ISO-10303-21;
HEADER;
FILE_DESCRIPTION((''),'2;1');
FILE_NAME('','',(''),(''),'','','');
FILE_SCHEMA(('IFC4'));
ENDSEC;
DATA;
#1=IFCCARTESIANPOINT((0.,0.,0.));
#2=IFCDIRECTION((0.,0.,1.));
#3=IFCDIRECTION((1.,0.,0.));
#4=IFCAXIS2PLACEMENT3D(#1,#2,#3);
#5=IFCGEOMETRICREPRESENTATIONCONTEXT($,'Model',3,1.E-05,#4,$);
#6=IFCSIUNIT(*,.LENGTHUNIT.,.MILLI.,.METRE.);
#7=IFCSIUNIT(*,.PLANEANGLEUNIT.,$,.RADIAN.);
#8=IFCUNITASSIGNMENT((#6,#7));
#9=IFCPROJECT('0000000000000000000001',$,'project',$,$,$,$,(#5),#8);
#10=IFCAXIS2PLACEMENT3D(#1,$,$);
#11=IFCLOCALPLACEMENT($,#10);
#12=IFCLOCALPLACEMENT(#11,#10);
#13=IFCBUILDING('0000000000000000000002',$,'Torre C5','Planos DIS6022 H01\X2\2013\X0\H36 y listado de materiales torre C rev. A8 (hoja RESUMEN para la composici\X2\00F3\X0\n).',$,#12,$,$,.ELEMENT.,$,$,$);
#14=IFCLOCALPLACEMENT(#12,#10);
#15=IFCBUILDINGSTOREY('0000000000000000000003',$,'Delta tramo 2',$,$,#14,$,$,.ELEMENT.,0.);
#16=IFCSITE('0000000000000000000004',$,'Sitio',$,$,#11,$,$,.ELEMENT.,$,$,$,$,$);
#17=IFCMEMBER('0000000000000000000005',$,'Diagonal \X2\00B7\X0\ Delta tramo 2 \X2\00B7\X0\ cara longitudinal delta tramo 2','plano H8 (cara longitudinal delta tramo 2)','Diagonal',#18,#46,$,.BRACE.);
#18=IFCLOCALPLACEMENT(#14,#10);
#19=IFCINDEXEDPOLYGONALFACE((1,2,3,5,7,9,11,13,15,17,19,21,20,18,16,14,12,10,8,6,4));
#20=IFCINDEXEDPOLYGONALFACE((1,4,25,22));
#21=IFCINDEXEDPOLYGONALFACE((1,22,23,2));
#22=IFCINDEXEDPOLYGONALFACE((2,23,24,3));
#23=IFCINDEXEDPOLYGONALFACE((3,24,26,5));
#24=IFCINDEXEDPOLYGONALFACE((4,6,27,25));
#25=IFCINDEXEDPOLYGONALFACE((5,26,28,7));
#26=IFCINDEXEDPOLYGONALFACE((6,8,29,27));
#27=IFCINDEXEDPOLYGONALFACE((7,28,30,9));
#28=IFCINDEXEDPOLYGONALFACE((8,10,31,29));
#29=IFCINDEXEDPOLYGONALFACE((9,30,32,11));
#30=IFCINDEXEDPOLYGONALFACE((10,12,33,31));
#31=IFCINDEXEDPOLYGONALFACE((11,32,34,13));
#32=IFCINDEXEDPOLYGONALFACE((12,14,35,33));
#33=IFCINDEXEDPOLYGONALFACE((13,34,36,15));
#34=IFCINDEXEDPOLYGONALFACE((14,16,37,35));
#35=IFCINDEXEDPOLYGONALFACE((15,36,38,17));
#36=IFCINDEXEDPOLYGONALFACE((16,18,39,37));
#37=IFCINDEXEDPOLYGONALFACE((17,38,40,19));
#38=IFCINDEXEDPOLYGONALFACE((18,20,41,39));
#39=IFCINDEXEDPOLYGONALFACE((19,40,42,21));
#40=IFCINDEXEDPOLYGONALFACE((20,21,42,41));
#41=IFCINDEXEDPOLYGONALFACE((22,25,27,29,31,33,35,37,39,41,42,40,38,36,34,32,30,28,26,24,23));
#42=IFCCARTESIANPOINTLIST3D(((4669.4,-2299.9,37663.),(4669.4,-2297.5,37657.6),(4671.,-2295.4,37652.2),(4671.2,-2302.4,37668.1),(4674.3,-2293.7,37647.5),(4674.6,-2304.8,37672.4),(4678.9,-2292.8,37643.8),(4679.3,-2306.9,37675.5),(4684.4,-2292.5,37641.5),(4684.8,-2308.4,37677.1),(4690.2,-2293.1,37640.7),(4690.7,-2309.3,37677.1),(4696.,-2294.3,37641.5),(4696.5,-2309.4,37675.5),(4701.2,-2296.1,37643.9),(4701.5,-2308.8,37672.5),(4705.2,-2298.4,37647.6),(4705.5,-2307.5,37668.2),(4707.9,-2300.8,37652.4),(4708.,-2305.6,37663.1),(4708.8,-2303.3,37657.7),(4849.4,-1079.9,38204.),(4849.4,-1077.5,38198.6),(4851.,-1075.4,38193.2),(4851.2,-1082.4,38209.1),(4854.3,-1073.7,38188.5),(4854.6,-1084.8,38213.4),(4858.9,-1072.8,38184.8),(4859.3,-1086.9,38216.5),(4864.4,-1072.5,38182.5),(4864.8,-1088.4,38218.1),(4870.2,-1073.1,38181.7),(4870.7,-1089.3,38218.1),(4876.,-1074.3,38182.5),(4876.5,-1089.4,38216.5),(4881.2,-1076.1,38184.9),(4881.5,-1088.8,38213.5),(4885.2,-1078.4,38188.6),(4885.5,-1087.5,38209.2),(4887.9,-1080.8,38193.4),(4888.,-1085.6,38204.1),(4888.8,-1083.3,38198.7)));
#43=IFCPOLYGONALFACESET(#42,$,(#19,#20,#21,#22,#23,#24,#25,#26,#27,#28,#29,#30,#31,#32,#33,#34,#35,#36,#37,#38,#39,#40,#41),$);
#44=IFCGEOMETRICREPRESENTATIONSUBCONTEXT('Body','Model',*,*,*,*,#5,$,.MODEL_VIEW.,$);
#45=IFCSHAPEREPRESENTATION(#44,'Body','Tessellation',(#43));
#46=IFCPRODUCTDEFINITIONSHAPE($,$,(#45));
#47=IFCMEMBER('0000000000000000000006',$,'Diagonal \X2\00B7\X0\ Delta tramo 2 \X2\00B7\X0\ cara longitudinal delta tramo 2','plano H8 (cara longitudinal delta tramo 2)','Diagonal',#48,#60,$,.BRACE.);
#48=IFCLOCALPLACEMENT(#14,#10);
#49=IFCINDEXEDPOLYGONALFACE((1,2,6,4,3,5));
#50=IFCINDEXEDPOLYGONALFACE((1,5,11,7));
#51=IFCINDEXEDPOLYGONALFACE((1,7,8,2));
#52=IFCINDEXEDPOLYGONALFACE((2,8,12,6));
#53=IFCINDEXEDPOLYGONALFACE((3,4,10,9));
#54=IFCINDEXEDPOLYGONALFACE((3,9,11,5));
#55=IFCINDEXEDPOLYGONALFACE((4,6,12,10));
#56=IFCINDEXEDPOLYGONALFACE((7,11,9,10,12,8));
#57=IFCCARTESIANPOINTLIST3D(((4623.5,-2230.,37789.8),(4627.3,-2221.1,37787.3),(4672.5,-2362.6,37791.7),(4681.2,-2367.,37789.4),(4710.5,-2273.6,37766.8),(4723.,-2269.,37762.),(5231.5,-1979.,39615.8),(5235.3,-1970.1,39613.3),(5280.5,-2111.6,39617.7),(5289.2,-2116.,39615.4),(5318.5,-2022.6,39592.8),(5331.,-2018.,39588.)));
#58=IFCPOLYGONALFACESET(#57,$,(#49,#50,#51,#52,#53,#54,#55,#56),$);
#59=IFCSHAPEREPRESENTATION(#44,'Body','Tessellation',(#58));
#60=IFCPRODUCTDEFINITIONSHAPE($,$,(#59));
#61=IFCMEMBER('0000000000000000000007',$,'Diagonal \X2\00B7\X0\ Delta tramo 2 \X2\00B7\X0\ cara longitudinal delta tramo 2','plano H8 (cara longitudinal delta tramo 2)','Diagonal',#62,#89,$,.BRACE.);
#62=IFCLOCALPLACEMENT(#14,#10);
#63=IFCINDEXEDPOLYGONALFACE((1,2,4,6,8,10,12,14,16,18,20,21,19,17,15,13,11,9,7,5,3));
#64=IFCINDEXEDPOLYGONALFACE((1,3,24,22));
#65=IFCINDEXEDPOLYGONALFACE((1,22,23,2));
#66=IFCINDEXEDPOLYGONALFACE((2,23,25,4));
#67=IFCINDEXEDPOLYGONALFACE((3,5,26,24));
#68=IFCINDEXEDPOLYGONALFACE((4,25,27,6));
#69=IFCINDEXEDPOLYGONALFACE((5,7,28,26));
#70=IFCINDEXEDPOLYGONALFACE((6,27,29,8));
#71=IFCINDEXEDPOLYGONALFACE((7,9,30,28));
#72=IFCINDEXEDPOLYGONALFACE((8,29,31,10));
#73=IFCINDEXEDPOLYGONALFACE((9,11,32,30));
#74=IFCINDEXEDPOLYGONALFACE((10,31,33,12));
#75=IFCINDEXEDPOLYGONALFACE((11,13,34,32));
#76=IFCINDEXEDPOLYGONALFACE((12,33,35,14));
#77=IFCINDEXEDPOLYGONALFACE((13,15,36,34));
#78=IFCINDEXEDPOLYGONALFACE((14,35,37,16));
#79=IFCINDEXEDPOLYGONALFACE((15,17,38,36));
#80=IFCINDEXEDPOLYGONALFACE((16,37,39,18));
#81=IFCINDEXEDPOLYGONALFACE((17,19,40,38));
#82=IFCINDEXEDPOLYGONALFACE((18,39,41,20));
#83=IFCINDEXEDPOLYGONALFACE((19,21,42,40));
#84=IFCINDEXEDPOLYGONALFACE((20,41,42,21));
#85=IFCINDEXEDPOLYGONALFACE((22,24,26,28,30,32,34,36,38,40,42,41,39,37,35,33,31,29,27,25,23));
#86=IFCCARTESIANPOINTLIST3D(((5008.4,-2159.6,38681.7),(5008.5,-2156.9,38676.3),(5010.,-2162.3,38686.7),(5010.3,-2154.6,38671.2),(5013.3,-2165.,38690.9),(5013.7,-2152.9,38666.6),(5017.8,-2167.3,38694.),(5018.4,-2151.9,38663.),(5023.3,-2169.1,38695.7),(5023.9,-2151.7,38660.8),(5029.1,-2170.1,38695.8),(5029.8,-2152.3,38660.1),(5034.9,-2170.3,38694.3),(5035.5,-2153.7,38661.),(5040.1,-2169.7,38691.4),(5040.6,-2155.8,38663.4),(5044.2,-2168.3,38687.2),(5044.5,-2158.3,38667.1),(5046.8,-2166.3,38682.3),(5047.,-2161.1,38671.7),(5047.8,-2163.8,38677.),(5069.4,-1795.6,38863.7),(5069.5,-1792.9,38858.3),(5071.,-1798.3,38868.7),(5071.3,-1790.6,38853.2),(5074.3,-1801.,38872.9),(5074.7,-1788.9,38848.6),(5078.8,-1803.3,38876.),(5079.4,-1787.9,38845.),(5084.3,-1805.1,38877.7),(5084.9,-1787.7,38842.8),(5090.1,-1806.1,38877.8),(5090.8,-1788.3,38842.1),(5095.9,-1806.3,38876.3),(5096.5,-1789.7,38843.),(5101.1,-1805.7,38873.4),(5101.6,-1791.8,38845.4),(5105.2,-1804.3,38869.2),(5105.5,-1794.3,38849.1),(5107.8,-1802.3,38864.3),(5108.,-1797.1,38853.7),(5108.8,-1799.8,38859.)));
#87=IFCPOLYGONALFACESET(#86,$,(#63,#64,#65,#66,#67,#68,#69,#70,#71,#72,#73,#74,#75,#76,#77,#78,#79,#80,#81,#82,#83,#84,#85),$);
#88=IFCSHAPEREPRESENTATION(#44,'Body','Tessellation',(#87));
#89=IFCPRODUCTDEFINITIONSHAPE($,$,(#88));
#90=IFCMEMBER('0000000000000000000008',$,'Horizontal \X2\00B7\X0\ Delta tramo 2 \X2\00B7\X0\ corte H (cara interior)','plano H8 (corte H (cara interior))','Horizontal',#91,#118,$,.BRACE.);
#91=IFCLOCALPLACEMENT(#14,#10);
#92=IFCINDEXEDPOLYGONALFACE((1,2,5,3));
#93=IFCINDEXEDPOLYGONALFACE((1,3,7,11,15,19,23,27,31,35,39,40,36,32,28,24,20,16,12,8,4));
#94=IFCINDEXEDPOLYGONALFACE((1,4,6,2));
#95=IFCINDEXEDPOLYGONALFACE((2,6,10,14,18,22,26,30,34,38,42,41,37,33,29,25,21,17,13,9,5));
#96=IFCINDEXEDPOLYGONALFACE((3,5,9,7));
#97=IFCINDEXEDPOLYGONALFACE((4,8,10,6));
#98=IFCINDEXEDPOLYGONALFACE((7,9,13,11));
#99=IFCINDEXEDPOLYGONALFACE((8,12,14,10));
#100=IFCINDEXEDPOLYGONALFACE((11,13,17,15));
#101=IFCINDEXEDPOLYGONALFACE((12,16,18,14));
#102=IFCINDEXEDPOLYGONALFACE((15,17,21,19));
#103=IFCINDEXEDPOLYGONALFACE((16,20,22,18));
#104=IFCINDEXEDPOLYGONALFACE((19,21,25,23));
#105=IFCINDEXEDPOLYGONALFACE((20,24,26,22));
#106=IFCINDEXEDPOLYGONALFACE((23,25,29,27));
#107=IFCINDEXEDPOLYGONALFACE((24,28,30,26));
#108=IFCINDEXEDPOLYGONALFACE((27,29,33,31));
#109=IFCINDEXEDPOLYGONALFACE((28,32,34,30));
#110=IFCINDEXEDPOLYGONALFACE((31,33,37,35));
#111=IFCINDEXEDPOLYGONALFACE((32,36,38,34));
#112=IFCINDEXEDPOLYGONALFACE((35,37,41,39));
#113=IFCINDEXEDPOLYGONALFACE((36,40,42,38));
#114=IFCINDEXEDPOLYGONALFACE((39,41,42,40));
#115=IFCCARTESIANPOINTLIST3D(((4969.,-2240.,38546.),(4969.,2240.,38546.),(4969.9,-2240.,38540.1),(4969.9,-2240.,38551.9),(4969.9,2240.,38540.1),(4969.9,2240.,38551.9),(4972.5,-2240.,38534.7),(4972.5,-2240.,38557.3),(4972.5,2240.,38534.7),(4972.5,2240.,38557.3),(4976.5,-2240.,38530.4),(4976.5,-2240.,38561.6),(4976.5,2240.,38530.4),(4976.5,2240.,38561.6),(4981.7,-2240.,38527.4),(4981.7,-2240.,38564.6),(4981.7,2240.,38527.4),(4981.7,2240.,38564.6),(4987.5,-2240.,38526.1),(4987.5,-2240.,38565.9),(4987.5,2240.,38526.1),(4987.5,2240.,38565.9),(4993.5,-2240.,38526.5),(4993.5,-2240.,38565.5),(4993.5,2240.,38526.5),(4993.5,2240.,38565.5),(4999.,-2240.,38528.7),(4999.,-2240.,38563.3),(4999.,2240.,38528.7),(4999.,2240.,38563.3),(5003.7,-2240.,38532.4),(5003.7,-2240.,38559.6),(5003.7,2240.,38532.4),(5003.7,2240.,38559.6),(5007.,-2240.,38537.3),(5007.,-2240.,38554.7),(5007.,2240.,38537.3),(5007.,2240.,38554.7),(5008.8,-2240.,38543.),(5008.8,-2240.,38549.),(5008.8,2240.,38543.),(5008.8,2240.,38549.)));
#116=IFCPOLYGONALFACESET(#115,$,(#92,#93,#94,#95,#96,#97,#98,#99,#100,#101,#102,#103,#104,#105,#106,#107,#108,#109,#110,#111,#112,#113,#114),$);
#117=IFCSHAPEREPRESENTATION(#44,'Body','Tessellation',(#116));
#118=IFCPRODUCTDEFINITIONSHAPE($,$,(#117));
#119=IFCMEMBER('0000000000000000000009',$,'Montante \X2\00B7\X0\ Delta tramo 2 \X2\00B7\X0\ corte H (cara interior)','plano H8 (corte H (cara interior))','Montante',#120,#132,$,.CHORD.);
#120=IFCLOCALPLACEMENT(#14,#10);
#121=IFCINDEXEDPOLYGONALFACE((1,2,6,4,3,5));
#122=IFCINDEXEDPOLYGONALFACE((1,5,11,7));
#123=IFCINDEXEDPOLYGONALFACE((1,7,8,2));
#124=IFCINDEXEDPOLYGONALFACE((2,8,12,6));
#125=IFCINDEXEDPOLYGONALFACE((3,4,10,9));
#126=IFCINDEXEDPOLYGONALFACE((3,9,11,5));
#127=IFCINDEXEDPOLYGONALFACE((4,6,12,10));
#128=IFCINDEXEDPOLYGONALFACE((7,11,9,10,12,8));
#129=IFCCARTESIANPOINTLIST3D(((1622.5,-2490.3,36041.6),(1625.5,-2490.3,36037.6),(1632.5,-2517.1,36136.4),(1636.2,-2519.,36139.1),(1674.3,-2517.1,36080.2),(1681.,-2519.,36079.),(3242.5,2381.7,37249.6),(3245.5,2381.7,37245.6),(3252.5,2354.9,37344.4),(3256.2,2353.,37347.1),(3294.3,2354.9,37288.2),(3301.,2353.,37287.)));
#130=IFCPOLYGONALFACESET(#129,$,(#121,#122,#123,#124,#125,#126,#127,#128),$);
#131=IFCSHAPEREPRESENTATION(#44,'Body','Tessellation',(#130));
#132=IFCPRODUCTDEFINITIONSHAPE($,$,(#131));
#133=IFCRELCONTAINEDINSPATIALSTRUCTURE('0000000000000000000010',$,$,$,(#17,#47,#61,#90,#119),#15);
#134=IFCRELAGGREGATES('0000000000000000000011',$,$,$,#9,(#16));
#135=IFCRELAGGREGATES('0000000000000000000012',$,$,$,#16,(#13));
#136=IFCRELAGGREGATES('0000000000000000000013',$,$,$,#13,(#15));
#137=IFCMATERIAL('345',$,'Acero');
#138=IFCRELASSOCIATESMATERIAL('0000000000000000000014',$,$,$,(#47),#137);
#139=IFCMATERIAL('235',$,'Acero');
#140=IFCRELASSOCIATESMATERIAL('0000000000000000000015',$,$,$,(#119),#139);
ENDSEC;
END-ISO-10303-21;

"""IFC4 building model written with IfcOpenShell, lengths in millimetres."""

from ifc_helpers import new_model, si_unit, frame, frame_2d, origin, origin_with_axes, place, context, subcontext, project, spatial, circle, l_section, extrude, material, element, save


model = new_model("IFC4")

# Units and contexts
model_context = context("Model", 3, precision=1e-05, world=origin_with_axes())
body_context = subcontext(model_context, "Body", "Model", "MODEL_VIEW")
ifc_project = project(units=[si_unit("LENGTHUNIT", "METRE", prefix="MILLI"), si_unit("PLANEANGLEUNIT", "RADIAN")], contexts=[model_context])

# Site, building, storey
site_placement = place(None, origin())
site = spatial("IfcSite", under=ifc_project, at=site_placement, Name="Sitio", CompositionType="ELEMENT")
building_placement = place(site_placement, origin())
building = spatial("IfcBuilding", under=site, at=building_placement, Name="Torre C5", Description="Planos DIS6022 H01–H36 y listado de materiales torre C rev. A8 (hoja RESUMEN para la composición).", CompositionType="ELEMENT")
storey_placement = place(building_placement, origin())
storey = spatial("IfcBuildingStorey", under=building, at=storey_placement, Name="Delta tramo 2", CompositionType="ELEMENT", Elevation=0.0)

# Members
ifc_material_1 = material(Name="345", Category="Acero")
ifc_material_2 = material(Name="235", Category="Acero")
member_1_placement = place(storey_placement, frame((4689.0, -2301.0, 37659.0), z_axis=(0.133664, 0.905948, 0.401736), x_axis=(-0.981631, 0.176718, -0.071907)))
element("IfcMember", 1, at=member_1_placement, inside=storey, Name="Diagonal · Delta tramo 2 · cara longitudinal delta tramo 2", Description="plano H8 (cara longitudinal delta tramo 2)", ObjectType="Diagonal", PredefinedType="BRACE", context=body_context, shape_type="SweptSolid", body=[
    extrude(circle(Radius=20.0), None, (0.0, 0.0, 1.0), 1346.7),
])
member_2_placement = place(storey_placement, frame((4723.0, -2269.0, 37762.0), z_axis=(0.313263, 0.129324, 0.94082), x_axis=(-0.870378, 0.435386, 0.22996)))
element("IfcMember", 2, at=member_2_placement, inside=storey, material=ifc_material_1, Name="Diagonal · Delta tramo 2 · cara longitudinal delta tramo 2", Description="plano H8 (cara longitudinal delta tramo 2)", ObjectType="Diagonal", PredefinedType="BRACE", context=body_context, shape_type="SweptSolid", body=[
    extrude(l_section(Depth=110.0, Width=110.0, Thickness=10.0, at=frame_2d((55.0, 55.0))), None, (0.0, 0.0, 1.0), 1940.9),
])
member_3_placement = place(storey_placement, frame((5028.0, -2161.0, 38678.0), z_axis=(0.148234, 0.884546, 0.442273), x_axis=(-0.975269, 0.204886, -0.082896)))
element("IfcMember", 3, at=member_3_placement, inside=storey, Name="Diagonal · Delta tramo 2 · cara longitudinal delta tramo 2", Description="plano H8 (cara longitudinal delta tramo 2)", ObjectType="Diagonal", PredefinedType="BRACE", context=body_context, shape_type="SweptSolid", body=[
    extrude(circle(Radius=20.0), None, (0.0, 0.0, 1.0), 411.5),
])
member_4_placement = place(storey_placement, frame((4989.0, -2240.0, 38546.0), z_axis=(0.0, 1.0, 0.0), x_axis=(-1.0, 0.0, 0.0)))
element("IfcMember", 4, at=member_4_placement, inside=storey, Name="Horizontal · Delta tramo 2 · corte H (cara interior)", Description="plano H8 (corte H (cara interior))", ObjectType="Horizontal", PredefinedType="BRACE", context=body_context, shape_type="SweptSolid", body=[
    extrude(circle(Radius=20.0), None, (0.0, 0.0, 1.0), 4480.0),
])
member_5_placement = place(storey_placement, frame((1681.0, -2519.0, 36079.0), z_axis=(0.30714, 0.923694, 0.229028), x_axis=(-0.740489, 0.38313, -0.552167)))
element("IfcMember", 5, at=member_5_placement, inside=storey, material=ifc_material_2, Name="Montante · Delta tramo 2 · corte H (cara interior)", Description="plano H8 (corte H (cara interior))", ObjectType="Montante", PredefinedType="CHORD", context=body_context, shape_type="SweptSolid", body=[
    extrude(l_section(Depth=75.0, Width=75.0, Thickness=5.0, at=frame_2d((37.5, 37.5))), None, (0.0, 0.0, 1.0), 5274.5),
])

save(model, "model.ifc")
